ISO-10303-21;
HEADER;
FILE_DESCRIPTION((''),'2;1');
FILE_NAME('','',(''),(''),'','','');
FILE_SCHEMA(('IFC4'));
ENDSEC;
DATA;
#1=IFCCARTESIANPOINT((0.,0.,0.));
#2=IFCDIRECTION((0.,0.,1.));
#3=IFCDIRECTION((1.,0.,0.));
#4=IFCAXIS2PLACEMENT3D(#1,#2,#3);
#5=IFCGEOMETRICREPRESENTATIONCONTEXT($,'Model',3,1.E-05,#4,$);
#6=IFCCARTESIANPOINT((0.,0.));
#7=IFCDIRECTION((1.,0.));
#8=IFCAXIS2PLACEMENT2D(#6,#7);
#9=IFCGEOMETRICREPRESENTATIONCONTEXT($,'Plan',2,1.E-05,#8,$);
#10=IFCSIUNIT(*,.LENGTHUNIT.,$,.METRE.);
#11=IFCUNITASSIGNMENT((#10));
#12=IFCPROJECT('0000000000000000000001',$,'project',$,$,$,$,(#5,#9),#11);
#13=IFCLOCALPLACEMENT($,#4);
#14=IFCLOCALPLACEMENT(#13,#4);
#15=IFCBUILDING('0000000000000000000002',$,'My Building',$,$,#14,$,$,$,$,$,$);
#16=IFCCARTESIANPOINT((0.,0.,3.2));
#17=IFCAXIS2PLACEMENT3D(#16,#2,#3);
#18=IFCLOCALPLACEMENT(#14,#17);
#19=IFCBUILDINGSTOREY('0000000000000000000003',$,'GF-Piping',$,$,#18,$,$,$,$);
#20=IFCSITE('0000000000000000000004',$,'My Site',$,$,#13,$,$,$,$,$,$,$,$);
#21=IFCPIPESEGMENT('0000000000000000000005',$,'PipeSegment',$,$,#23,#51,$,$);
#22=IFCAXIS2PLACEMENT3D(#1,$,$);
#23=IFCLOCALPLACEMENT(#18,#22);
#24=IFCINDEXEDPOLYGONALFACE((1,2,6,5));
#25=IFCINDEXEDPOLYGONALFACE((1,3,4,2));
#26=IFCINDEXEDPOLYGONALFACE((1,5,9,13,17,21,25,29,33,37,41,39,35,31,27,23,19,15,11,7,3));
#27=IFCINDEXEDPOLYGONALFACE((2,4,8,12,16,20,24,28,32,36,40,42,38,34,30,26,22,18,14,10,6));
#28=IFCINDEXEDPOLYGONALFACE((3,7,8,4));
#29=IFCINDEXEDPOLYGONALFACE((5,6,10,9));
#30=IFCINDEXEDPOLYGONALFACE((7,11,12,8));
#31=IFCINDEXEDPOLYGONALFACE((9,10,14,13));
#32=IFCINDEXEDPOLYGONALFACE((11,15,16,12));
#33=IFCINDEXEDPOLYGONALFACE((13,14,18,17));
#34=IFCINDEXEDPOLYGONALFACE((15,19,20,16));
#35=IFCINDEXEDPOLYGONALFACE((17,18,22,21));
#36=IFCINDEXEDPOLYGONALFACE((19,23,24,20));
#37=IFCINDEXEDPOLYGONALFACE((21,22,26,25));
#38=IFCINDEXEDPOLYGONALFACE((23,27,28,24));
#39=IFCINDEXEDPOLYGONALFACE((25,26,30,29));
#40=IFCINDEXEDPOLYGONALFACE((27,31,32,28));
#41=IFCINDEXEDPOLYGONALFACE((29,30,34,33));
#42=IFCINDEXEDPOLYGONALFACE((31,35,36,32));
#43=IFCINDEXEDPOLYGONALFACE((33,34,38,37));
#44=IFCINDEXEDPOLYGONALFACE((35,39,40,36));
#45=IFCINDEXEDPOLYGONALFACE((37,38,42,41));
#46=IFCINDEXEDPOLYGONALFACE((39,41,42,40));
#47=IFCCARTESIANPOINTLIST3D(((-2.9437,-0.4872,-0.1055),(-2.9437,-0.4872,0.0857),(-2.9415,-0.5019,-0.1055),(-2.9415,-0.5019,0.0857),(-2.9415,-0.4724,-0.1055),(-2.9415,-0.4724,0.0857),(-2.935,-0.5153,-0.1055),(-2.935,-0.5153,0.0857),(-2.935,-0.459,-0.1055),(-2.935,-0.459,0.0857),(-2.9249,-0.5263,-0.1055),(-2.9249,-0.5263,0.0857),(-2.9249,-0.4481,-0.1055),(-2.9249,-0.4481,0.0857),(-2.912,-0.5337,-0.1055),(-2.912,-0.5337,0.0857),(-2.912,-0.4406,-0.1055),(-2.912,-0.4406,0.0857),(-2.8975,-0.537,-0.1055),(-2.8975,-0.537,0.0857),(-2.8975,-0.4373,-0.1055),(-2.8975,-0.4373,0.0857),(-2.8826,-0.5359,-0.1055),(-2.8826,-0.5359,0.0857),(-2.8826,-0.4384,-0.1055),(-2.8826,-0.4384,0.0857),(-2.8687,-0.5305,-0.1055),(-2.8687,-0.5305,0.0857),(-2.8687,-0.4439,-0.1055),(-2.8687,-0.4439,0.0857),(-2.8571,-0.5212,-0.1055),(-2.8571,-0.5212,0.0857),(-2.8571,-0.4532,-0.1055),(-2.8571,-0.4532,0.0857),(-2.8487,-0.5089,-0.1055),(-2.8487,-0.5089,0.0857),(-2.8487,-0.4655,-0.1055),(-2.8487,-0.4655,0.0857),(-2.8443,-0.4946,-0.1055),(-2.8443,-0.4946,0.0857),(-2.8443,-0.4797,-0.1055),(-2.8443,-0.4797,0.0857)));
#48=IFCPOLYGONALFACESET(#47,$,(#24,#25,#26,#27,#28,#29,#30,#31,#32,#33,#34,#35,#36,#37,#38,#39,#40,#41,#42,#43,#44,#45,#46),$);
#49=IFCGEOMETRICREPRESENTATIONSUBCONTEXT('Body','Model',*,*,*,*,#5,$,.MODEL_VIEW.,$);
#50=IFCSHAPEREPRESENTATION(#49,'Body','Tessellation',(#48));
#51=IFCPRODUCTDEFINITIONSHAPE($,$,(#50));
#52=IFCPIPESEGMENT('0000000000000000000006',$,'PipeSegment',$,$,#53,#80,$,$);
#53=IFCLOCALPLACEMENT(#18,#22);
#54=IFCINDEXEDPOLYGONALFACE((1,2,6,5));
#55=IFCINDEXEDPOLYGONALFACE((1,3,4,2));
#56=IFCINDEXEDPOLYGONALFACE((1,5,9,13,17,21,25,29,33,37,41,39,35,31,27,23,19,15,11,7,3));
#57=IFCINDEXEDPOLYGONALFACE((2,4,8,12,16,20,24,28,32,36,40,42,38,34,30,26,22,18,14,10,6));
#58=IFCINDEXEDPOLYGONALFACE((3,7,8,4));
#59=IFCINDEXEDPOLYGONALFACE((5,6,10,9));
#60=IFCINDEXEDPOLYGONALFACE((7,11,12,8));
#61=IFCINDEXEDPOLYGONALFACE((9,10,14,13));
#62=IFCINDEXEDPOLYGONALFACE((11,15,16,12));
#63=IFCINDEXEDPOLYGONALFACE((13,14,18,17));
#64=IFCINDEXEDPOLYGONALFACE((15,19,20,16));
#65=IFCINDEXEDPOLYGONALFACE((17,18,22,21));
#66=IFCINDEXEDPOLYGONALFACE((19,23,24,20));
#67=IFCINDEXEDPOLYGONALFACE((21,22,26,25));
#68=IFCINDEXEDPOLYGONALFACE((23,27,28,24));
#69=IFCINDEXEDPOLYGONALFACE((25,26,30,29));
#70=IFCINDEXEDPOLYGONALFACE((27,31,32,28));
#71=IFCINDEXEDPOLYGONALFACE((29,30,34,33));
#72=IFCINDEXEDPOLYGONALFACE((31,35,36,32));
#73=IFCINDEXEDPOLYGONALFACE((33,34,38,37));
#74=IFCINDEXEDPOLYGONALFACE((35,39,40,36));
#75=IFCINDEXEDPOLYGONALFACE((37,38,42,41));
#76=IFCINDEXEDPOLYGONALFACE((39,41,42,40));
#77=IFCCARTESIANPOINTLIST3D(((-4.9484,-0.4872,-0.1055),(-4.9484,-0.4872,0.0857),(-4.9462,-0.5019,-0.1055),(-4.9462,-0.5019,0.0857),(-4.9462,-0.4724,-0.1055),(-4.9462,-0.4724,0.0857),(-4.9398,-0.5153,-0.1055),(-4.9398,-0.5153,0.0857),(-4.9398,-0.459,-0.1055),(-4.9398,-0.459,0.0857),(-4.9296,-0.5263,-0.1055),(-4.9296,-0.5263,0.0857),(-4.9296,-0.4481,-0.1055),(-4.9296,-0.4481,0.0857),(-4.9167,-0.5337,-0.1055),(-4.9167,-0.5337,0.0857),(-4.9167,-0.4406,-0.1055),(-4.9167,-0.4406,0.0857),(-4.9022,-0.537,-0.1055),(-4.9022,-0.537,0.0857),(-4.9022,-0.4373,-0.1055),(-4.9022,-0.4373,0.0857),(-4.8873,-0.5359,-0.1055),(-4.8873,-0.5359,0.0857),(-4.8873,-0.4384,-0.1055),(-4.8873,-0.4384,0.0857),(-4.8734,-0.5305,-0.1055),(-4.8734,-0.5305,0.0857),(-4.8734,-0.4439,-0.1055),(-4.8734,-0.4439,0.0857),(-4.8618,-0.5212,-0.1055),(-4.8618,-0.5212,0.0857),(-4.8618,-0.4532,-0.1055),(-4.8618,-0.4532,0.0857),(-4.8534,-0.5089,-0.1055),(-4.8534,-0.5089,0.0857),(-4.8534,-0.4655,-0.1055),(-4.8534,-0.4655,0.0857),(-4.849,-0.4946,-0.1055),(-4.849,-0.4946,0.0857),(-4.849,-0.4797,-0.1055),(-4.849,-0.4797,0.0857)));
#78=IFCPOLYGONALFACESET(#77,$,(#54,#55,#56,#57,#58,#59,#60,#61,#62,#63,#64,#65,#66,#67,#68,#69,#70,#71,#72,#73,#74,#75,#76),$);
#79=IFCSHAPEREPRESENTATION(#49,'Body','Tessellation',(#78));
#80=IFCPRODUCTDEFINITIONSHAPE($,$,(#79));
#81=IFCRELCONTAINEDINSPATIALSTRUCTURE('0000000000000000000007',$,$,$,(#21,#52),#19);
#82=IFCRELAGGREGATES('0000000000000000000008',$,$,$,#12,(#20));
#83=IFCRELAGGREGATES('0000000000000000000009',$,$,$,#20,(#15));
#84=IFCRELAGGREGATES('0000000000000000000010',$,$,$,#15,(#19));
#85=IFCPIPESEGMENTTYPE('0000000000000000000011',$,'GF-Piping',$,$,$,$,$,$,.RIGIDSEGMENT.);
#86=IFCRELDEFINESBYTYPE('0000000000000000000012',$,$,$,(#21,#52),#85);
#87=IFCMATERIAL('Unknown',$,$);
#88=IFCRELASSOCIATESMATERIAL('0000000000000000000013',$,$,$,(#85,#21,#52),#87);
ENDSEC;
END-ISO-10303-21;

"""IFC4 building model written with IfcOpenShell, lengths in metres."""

from ifc_helpers import new_model, si_unit, frame, origin_with_axes, origin_2d_with_axis, place, context, subcontext, project, spatial, circle, extrude, material, material_profile, profile_set, profile_usage, type_object, element, save


model = new_model("IFC4")

# Units and contexts
model_context = context("Model", 3, precision=1e-05, world=origin_with_axes())
plan_context = context("Plan", 2, precision=1e-05, world=origin_2d_with_axis())
body_context = subcontext(model_context, "Body", "Model", "MODEL_VIEW")
ifc_project = project(units=[si_unit("LENGTHUNIT", "METRE")], contexts=[model_context, plan_context])

# Site, building, storey
site_placement = place(None, origin_with_axes())
site = spatial("IfcSite", under=ifc_project, at=site_placement, Name="My Site")
building_placement = place(site_placement, origin_with_axes())
building = spatial("IfcBuilding", under=site, at=building_placement, Name="My Building")
storey_placement = place(building_placement, frame((0.0, 0.0, 3.2), z_axis=(0.0, 0.0, 1.0), x_axis=(1.0, 0.0, 0.0)))
storey = spatial("IfcBuildingStorey", under=building, at=storey_placement, Name="GF-Piping")

# Pipe segments
ifc_material = material(Name="Unknown")
ifc_material_profile = material_profile(ifc_material, circle(Radius=0.05))
ifc_profile_set = profile_set([ifc_material_profile])
pipe_segment_type = type_object("IfcPipeSegmentType", Name="GF-Piping", PredefinedType="RIGIDSEGMENT", material=ifc_profile_set)
ifc_profile_usage_1 = profile_usage(ifc_profile_set, cardinal=5)
pipe_segment_1_placement = place(storey_placement, frame((-2.8937, -0.4872, 0.0857), z_axis=(0.0, 0.0, -1.0), x_axis=(-1.0, 0.0, 0.0)))
element("IfcPipeSegment", 1, at=pipe_segment_1_placement, inside=storey, type_object=pipe_segment_type, material=ifc_profile_usage_1, Name="PipeSegment", context=body_context, shape_type="SweptSolid", body=[
    extrude(circle(Radius=0.05), origin_with_axes(), (0.0, 0.0, 1.0), 0.1912),
])
ifc_profile_usage_2 = profile_usage(ifc_profile_set, cardinal=5)
pipe_segment_2_placement = place(storey_placement, frame((-4.8984, -0.4872, 0.0857), z_axis=(0.0, 0.0, -1.0), x_axis=(-1.0, 0.0, 0.0)))
element("IfcPipeSegment", 2, at=pipe_segment_2_placement, inside=storey, type_object=pipe_segment_type, material=ifc_profile_usage_2, Name="PipeSegment", context=body_context, shape_type="SweptSolid", body=[
    extrude(circle(Radius=0.05), origin_with_axes(), (0.0, 0.0, 1.0), 0.1912),
])

save(model, "model.ifc")
